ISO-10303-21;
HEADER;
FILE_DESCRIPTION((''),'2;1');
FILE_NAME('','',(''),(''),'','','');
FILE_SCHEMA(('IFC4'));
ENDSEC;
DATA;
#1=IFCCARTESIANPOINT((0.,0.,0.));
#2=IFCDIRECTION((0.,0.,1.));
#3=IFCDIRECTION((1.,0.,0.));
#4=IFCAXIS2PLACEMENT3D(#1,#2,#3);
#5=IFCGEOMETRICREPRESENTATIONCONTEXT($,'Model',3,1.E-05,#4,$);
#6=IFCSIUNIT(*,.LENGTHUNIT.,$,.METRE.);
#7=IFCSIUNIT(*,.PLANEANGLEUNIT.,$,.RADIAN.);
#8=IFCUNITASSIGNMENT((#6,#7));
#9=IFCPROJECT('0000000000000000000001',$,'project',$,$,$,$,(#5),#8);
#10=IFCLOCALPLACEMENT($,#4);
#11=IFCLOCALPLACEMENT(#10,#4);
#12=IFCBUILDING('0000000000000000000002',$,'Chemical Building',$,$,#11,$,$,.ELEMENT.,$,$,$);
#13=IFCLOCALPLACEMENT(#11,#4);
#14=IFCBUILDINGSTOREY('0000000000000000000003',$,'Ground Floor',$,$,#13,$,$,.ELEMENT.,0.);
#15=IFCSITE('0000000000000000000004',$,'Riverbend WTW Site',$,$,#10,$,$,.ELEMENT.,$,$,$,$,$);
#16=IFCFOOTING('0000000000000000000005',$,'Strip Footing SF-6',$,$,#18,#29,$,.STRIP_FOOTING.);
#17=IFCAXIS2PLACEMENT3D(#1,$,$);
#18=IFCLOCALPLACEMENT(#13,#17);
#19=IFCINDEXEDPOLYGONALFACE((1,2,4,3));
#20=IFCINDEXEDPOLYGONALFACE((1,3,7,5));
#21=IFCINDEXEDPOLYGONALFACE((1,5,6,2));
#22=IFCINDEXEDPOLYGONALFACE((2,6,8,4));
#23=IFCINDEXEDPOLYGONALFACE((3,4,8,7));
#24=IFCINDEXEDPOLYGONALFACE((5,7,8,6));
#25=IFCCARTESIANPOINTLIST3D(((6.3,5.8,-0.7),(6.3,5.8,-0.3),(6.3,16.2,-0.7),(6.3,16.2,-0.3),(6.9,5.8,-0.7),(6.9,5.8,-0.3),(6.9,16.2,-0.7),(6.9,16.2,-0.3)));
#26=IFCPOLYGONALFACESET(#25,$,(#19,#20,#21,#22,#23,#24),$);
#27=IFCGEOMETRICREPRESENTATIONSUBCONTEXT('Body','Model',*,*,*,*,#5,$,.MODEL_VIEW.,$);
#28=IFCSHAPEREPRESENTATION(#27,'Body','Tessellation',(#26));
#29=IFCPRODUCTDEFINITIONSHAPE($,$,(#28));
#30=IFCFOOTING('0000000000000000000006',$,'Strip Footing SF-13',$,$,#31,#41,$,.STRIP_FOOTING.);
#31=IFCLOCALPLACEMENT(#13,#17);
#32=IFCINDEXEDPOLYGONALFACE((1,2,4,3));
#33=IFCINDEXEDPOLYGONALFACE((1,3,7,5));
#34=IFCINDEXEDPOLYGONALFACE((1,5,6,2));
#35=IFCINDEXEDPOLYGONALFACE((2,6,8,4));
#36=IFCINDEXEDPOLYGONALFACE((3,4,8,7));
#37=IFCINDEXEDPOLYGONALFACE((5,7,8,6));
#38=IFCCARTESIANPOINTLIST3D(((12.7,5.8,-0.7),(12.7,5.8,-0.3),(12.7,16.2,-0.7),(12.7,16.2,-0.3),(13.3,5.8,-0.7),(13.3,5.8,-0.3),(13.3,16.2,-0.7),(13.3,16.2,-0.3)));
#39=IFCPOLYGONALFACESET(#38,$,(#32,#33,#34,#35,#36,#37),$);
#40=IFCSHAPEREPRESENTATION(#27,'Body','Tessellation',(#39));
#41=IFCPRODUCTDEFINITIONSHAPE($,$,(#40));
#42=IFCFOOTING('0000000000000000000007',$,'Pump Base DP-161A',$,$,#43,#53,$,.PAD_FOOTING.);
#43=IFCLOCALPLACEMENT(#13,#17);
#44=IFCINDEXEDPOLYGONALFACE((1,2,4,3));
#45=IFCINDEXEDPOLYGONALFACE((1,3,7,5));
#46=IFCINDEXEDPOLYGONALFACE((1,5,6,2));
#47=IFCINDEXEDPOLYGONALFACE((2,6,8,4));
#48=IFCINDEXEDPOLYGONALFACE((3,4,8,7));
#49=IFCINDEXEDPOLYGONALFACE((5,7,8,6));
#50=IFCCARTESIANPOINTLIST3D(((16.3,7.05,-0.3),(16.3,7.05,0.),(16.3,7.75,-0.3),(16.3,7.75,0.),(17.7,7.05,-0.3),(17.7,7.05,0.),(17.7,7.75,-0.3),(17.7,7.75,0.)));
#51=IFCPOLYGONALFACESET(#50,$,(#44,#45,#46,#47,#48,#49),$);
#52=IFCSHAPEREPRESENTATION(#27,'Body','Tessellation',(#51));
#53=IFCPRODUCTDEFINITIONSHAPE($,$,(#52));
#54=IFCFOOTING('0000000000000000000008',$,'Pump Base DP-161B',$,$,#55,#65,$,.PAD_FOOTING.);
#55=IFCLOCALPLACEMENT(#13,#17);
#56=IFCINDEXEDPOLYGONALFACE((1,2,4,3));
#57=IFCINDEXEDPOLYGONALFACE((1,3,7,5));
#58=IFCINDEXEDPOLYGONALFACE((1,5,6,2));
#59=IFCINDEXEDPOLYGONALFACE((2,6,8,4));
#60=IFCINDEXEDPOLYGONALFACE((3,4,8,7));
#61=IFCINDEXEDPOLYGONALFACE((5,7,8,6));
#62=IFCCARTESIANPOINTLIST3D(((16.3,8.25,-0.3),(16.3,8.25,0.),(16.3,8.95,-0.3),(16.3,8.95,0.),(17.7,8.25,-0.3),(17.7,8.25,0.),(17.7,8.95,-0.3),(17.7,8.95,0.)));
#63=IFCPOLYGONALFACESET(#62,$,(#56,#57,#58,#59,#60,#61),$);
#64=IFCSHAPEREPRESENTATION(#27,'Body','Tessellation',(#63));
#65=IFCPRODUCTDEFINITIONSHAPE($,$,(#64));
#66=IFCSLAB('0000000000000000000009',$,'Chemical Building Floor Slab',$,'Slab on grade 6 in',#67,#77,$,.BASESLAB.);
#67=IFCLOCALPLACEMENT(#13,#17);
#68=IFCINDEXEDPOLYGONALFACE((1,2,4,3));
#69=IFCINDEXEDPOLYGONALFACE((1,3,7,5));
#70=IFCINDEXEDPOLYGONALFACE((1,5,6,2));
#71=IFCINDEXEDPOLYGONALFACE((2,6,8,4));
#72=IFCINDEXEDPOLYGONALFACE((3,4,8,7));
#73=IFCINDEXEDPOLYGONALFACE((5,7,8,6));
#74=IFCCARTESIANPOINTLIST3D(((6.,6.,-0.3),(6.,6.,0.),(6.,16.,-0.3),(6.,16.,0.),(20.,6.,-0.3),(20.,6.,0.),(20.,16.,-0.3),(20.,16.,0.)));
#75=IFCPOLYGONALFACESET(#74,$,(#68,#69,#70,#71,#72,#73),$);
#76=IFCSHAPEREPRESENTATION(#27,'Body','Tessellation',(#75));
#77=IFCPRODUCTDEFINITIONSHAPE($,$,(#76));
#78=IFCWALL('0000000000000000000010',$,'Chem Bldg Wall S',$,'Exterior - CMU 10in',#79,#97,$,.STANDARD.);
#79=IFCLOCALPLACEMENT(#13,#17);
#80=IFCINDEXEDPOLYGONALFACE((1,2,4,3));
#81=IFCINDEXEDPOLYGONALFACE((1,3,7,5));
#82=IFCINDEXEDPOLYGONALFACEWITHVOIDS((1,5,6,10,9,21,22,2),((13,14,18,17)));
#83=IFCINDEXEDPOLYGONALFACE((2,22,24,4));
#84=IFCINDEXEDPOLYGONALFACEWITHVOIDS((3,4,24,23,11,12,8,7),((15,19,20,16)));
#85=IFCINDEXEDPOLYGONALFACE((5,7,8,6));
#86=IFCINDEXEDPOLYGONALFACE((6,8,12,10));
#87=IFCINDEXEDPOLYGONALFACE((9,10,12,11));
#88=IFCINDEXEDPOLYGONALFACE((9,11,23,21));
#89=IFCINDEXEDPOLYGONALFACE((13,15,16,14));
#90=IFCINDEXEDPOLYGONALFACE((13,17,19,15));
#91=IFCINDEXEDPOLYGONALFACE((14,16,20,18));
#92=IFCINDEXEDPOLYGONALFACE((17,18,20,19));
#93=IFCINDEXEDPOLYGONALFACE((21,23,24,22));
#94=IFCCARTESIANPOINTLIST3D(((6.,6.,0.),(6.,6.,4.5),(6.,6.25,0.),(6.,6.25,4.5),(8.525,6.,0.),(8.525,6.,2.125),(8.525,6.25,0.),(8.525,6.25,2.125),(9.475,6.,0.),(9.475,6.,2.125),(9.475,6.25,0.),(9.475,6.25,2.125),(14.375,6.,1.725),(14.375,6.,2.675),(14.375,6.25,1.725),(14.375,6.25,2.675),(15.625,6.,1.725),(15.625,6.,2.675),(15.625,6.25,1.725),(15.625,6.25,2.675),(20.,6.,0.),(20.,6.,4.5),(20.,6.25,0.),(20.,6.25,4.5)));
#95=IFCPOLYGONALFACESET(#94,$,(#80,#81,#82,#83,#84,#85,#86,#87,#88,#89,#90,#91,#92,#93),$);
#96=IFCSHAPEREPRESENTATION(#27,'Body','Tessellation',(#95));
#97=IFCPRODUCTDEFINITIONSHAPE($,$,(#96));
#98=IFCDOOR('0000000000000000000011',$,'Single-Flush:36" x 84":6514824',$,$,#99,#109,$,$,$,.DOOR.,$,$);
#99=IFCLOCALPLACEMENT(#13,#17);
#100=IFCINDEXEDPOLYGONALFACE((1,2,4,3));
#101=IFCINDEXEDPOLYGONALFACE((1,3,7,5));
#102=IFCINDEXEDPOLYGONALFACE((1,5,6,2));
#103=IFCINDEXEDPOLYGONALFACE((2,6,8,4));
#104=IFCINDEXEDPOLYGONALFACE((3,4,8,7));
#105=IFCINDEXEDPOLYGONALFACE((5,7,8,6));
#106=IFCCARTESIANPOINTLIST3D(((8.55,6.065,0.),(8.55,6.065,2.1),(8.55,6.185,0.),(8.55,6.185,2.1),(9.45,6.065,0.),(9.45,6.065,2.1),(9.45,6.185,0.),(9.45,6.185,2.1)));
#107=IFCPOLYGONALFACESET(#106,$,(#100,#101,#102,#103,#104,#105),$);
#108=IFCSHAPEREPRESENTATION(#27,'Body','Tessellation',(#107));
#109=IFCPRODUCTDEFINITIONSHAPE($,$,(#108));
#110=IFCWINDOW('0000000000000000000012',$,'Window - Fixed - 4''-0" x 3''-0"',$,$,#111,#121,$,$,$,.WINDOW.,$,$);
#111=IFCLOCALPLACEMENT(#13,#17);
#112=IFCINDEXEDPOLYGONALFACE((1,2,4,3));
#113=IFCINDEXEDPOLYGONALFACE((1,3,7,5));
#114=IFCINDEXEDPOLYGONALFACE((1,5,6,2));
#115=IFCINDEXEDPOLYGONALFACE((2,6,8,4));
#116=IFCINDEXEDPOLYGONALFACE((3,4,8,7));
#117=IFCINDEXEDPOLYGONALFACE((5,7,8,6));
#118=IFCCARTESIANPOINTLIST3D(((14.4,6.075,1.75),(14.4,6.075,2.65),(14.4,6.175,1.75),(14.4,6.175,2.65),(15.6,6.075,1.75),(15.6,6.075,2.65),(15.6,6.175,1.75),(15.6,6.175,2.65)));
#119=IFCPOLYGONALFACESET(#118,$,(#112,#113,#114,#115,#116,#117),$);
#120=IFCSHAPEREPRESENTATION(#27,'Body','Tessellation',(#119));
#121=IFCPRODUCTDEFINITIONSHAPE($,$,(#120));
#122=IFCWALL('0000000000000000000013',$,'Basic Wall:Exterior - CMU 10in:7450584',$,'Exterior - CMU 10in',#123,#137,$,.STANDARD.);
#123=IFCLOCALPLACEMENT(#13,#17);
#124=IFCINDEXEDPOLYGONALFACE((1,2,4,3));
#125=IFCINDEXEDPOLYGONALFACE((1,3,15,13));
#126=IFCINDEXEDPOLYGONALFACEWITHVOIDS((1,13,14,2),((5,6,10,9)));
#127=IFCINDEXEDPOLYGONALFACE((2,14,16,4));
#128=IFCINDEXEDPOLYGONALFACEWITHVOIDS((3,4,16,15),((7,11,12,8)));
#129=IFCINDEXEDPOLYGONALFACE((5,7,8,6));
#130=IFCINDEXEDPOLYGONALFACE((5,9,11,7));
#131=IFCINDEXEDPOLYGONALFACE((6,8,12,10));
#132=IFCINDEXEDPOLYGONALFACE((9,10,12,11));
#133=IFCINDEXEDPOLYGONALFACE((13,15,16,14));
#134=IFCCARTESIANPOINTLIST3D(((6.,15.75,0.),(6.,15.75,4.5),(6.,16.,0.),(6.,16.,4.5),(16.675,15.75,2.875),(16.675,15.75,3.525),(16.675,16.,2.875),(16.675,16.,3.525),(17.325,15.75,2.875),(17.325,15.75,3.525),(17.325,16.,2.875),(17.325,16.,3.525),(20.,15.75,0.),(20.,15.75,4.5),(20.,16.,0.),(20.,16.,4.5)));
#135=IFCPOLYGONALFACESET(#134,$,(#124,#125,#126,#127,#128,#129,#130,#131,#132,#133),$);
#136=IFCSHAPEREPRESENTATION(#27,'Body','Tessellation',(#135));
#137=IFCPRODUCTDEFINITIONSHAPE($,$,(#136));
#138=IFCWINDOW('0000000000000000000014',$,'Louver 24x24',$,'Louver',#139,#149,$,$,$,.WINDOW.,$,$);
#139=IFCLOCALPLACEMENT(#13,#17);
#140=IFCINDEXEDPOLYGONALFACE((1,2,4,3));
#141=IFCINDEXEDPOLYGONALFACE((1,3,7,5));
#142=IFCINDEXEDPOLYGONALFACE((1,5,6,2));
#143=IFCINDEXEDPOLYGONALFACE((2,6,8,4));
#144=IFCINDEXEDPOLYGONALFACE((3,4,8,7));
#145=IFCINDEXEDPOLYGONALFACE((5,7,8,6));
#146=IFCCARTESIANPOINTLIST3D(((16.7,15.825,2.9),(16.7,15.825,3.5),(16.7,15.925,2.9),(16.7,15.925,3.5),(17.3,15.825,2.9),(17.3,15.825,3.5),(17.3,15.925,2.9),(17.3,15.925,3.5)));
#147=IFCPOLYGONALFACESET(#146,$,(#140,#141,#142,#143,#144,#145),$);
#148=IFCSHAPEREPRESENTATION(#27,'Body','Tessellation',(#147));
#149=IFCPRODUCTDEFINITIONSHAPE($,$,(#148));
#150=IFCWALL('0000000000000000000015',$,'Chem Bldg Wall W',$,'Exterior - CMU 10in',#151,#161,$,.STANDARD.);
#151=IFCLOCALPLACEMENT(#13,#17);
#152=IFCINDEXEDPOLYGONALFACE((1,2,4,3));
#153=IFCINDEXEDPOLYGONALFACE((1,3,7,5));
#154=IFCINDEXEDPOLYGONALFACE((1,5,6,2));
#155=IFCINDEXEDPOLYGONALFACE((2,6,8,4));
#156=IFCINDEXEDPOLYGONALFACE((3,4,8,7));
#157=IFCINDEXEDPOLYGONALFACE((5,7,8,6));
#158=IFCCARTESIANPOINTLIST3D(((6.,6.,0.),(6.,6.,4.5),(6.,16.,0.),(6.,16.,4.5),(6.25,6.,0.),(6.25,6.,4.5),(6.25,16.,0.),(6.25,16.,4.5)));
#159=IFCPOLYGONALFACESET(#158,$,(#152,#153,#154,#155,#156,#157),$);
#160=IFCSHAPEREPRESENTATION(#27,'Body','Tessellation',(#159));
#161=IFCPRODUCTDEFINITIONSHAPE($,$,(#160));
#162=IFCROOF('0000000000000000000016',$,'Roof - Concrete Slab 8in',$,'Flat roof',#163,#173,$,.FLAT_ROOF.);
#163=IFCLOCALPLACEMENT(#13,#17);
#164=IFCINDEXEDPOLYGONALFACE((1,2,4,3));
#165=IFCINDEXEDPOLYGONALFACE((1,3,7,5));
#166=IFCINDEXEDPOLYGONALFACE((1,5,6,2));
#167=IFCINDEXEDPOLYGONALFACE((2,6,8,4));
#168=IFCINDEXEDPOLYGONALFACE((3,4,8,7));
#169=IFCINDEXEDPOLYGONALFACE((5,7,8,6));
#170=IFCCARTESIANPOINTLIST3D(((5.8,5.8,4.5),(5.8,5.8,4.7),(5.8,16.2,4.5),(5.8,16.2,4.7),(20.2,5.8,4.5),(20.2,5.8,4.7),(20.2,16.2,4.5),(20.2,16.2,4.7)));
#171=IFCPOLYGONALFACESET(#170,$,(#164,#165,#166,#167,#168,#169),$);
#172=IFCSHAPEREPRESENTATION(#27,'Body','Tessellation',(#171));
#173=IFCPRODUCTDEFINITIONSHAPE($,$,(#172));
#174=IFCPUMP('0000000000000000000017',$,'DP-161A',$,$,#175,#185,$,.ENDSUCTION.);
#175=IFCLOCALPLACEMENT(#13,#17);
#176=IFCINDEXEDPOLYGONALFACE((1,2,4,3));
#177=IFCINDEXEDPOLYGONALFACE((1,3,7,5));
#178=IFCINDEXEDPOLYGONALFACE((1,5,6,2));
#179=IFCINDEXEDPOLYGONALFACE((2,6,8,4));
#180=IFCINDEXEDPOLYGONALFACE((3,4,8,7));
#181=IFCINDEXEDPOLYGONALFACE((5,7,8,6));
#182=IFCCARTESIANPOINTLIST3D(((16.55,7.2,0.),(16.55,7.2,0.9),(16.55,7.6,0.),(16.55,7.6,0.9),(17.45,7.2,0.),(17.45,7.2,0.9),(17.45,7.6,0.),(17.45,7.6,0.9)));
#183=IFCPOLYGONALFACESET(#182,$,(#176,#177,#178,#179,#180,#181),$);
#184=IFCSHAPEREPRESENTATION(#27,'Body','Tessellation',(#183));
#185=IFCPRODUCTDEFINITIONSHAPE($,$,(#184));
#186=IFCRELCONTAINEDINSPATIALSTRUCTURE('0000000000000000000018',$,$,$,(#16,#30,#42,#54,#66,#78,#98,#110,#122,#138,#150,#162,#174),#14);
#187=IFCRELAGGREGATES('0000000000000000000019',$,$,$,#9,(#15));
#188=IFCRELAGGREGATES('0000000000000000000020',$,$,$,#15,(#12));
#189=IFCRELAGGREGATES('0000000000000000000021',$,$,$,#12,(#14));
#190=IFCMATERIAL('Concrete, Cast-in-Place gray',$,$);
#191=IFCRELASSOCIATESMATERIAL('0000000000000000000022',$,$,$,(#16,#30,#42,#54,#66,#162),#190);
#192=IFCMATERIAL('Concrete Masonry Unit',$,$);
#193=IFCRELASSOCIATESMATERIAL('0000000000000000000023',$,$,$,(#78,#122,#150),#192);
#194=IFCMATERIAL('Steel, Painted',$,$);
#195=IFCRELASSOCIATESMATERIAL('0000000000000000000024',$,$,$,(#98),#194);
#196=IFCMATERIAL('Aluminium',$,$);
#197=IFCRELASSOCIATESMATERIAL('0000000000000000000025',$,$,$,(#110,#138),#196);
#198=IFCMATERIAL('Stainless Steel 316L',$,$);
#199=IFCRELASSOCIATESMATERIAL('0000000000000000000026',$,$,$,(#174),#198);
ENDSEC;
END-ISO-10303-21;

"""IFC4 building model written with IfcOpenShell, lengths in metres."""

from ifc_helpers import new_model, si_unit, frame, origin_with_axes, origin_2d, place, context, subcontext, project, spatial, rectangle, extrude, material, element, fill, save


model = new_model("IFC4")

# Units and contexts
model_context = context("Model", 3, precision=1e-05, world=origin_with_axes())
body_context = subcontext(model_context, "Body", "Model", "MODEL_VIEW")
ifc_project = project(units=[si_unit("LENGTHUNIT", "METRE"), si_unit("PLANEANGLEUNIT", "RADIAN")], contexts=[model_context])

# Site, building, storey
site_placement = place(None, origin_with_axes())
site = spatial("IfcSite", under=ifc_project, at=site_placement, Name="Riverbend WTW Site", CompositionType="ELEMENT")
building_placement = place(site_placement, origin_with_axes())
building = spatial("IfcBuilding", under=site, at=building_placement, Name="Chemical Building", CompositionType="ELEMENT")
storey_placement = place(building_placement, origin_with_axes())
storey = spatial("IfcBuildingStorey", under=building, at=storey_placement, Name="Ground Floor", CompositionType="ELEMENT", Elevation=0.0)

# Footings
ifc_material_1 = material(Name="Concrete, Cast-in-Place gray")
for number, where, z_axis, x_axis, name in (
    (1, (6.6, 11.0, -0.5), (0.0, 0.0, 1.0), (1.0, 0.0, 0.0), "Strip Footing SF-6"),
    (2, (13.0, 11.0, -0.5), (0.0, 0.0, 1.0), (1.0, 0.0, 0.0), "Strip Footing SF-13"),
):
    element("IfcFooting", number, at=place(None, frame(where, z_axis=z_axis, x_axis=x_axis)), inside=storey, material=ifc_material_1, Name=name, PredefinedType="STRIP_FOOTING", context=body_context, shape_type="SweptSolid", body=[
        extrude(rectangle(XDim=0.6, YDim=10.4, at=origin_2d()), frame((0.0, 0.0, -0.2), z_axis=(0.0, 0.0, 1.0), x_axis=(1.0, 0.0, 0.0)), (0.0, 0.0, 1.0), 0.4),
    ])
for number, where, z_axis, x_axis, name in (
    (3, (17.0, 7.4, -0.15), (0.0, 0.0, 1.0), (1.0, 0.0, 0.0), "Pump Base DP-161A"),
    (4, (17.0, 8.6, -0.15), (0.0, 0.0, 1.0), (1.0, 0.0, 0.0), "Pump Base DP-161B"),
):
    element("IfcFooting", number, at=place(None, frame(where, z_axis=z_axis, x_axis=x_axis)), inside=storey, material=ifc_material_1, Name=name, PredefinedType="PAD_FOOTING", context=body_context, shape_type="SweptSolid", body=[
        extrude(rectangle(XDim=1.4, YDim=0.7, at=origin_2d()), frame((0.0, 0.0, -0.15), z_axis=(0.0, 0.0, 1.0), x_axis=(1.0, 0.0, 0.0)), (0.0, 0.0, 1.0), 0.3),
    ])

# Slab
slab_placement = place(None, frame((13.0, 11.0, -0.15), z_axis=(0.0, 0.0, 1.0), x_axis=(1.0, 0.0, 0.0)))
element("IfcSlab", 5, at=slab_placement, inside=storey, material=ifc_material_1, Name="Chemical Building Floor Slab", ObjectType="Slab on grade 6 in", PredefinedType="BASESLAB", context=body_context, shape_type="SweptSolid", body=[
    extrude(rectangle(XDim=14.0, YDim=10.0, at=origin_2d()), frame((0.0, 0.0, -0.15), z_axis=(0.0, 0.0, 1.0), x_axis=(1.0, 0.0, 0.0)), (0.0, 0.0, 1.0), 0.3),
])

# Wall, openings, door, window
ifc_material_2 = material(Name="Concrete Masonry Unit")
wall_1_placement = place(None, frame((13.0, 6.125, 2.25), z_axis=(0.0, 0.0, 1.0), x_axis=(1.0, 0.0, 0.0)))
wall_1 = element("IfcWall", 6, at=wall_1_placement, inside=storey, material=ifc_material_2, Name="Chem Bldg Wall S", ObjectType="Exterior - CMU 10in", PredefinedType="STANDARD", context=body_context, shape_type="SweptSolid", body=[
    extrude(rectangle(XDim=14.0, YDim=0.25, at=origin_2d()), frame((0.0, 0.0, -2.25), z_axis=(0.0, 0.0, 1.0), x_axis=(1.0, 0.0, 0.0)), (0.0, 0.0, 1.0), 4.5),
])
opening_1_placement = place(None, frame((9.0, 6.125, 1.05), z_axis=(0.0, 0.0, 1.0), x_axis=(1.0, 0.0, 0.0)))
opening_1 = element("IfcOpeningElement", 7, at=opening_1_placement, inside=storey, cuts=wall_1, context=body_context, shape_type="SweptSolid", body=[
    extrude(rectangle(XDim=0.95, YDim=0.4, at=origin_2d()), frame((0.0, 0.0, -1.075), z_axis=(0.0, 0.0, 1.0), x_axis=(1.0, 0.0, 0.0)), (0.0, 0.0, 1.0), 2.15),
])
opening_2_placement = place(None, frame((15.0, 6.125, 2.2), z_axis=(0.0, 0.0, 1.0), x_axis=(1.0, 0.0, 0.0)))
opening_2 = element("IfcOpeningElement", 8, at=opening_2_placement, inside=storey, cuts=wall_1, context=body_context, shape_type="SweptSolid", body=[
    extrude(rectangle(XDim=1.25, YDim=0.4, at=origin_2d()), frame((0.0, 0.0, -0.475), z_axis=(0.0, 0.0, 1.0), x_axis=(1.0, 0.0, 0.0)), (0.0, 0.0, 1.0), 0.95),
])
ifc_material_3 = material(Name="Steel, Painted")
door_placement = place(None, frame((9.0, 6.125, 1.05), z_axis=(0.0, 0.0, 1.0), x_axis=(1.0, 0.0, 0.0)))
door = element("IfcDoor", 9, at=door_placement, inside=storey, material=ifc_material_3, Name="Single-Flush:36\" x 84\":6514824", PredefinedType="DOOR", context=body_context, shape_type="SweptSolid", body=[
    extrude(rectangle(XDim=0.9, YDim=0.12, at=origin_2d()), frame((0.0, 0.0, -1.05), z_axis=(0.0, 0.0, 1.0), x_axis=(1.0, 0.0, 0.0)), (0.0, 0.0, 1.0), 2.1),
])
fill(opening_1, door)
ifc_material_4 = material(Name="Aluminium")
window_1_placement = place(None, frame((15.0, 6.125, 2.2), z_axis=(0.0, 0.0, 1.0), x_axis=(1.0, 0.0, 0.0)))
window_1 = element("IfcWindow", 10, at=window_1_placement, inside=storey, material=ifc_material_4, Name="Window - Fixed - 4'-0\" x 3'-0\"", PredefinedType="WINDOW", context=body_context, shape_type="SweptSolid", body=[
    extrude(rectangle(XDim=1.2, YDim=0.1, at=origin_2d()), frame((0.0, 0.0, -0.45), z_axis=(0.0, 0.0, 1.0), x_axis=(1.0, 0.0, 0.0)), (0.0, 0.0, 1.0), 0.9),
])
fill(opening_2, window_1)

# Wall, opening, window
wall_2_placement = place(None, frame((13.0, 15.875, 2.25), z_axis=(0.0, 0.0, 1.0), x_axis=(1.0, 0.0, 0.0)))
wall_2 = element("IfcWall", 11, at=wall_2_placement, inside=storey, material=ifc_material_2, Name="Basic Wall:Exterior - CMU 10in:7450584", ObjectType="Exterior - CMU 10in", PredefinedType="STANDARD", context=body_context, shape_type="SweptSolid", body=[
    extrude(rectangle(XDim=14.0, YDim=0.25, at=origin_2d()), frame((0.0, 0.0, -2.25), z_axis=(0.0, 0.0, 1.0), x_axis=(1.0, 0.0, 0.0)), (0.0, 0.0, 1.0), 4.5),
])
opening_3_placement = place(None, frame((17.0, 15.875, 3.2), z_axis=(0.0, 0.0, 1.0), x_axis=(1.0, 0.0, 0.0)))
opening_3 = element("IfcOpeningElement", 12, at=opening_3_placement, inside=storey, cuts=wall_2, context=body_context, shape_type="SweptSolid", body=[
    extrude(rectangle(XDim=0.65, YDim=0.4, at=origin_2d()), frame((0.0, 0.0, -0.325), z_axis=(0.0, 0.0, 1.0), x_axis=(1.0, 0.0, 0.0)), (0.0, 0.0, 1.0), 0.65),
])
window_2_placement = place(None, frame((17.0, 15.875, 3.2), z_axis=(0.0, 0.0, 1.0), x_axis=(1.0, 0.0, 0.0)))
window_2 = element("IfcWindow", 13, at=window_2_placement, inside=storey, material=ifc_material_4, Name="Louver 24x24", ObjectType="Louver", PredefinedType="WINDOW", context=body_context, shape_type="SweptSolid", body=[
    extrude(rectangle(XDim=0.6, YDim=0.1, at=origin_2d()), frame((0.0, 0.0, -0.3), z_axis=(0.0, 0.0, 1.0), x_axis=(1.0, 0.0, 0.0)), (0.0, 0.0, 1.0), 0.6),
])
fill(opening_3, window_2)

# Wall
wall_3_placement = place(None, frame((6.125, 11.0, 2.25), z_axis=(0.0, 0.0, 1.0), x_axis=(1.0, 0.0, 0.0)))
element("IfcWall", 14, at=wall_3_placement, inside=storey, material=ifc_material_2, Name="Chem Bldg Wall W", ObjectType="Exterior - CMU 10in", PredefinedType="STANDARD", context=body_context, shape_type="SweptSolid", body=[
    extrude(rectangle(XDim=0.25, YDim=10.0, at=origin_2d()), frame((0.0, 0.0, -2.25), z_axis=(0.0, 0.0, 1.0), x_axis=(1.0, 0.0, 0.0)), (0.0, 0.0, 1.0), 4.5),
])

# Roof
roof_placement = place(None, frame((13.0, 11.0, 4.6), z_axis=(0.0, 0.0, 1.0), x_axis=(1.0, 0.0, 0.0)))
element("IfcRoof", 15, at=roof_placement, inside=storey, material=ifc_material_1, Name="Roof - Concrete Slab 8in", ObjectType="Flat roof", PredefinedType="FLAT_ROOF", context=body_context, shape_type="SweptSolid", body=[
    extrude(rectangle(XDim=14.4, YDim=10.4, at=origin_2d()), frame((0.0, 0.0, -0.1), z_axis=(0.0, 0.0, 1.0), x_axis=(1.0, 0.0, 0.0)), (0.0, 0.0, 1.0), 0.2),
])

# Pump
ifc_material_5 = material(Name="Stainless Steel 316L")
for number, where, z_axis, x_axis, name in (
    (16, (17.0, 7.4, 0.45), (0.0, 0.0, 1.0), (1.0, 0.0, 0.0), "DP-161A"),
):
    element("IfcPump", number, at=place(None, frame(where, z_axis=z_axis, x_axis=x_axis)), inside=storey, material=ifc_material_5, Name=name, PredefinedType="ENDSUCTION", context=body_context, shape_type="SweptSolid", body=[
        extrude(rectangle(XDim=0.9, YDim=0.4, at=origin_2d()), frame((0.0, 0.0, -0.45), z_axis=(0.0, 0.0, 1.0), x_axis=(1.0, 0.0, 0.0)), (0.0, 0.0, 1.0), 0.9),
    ])

save(model, "model.ifc")
